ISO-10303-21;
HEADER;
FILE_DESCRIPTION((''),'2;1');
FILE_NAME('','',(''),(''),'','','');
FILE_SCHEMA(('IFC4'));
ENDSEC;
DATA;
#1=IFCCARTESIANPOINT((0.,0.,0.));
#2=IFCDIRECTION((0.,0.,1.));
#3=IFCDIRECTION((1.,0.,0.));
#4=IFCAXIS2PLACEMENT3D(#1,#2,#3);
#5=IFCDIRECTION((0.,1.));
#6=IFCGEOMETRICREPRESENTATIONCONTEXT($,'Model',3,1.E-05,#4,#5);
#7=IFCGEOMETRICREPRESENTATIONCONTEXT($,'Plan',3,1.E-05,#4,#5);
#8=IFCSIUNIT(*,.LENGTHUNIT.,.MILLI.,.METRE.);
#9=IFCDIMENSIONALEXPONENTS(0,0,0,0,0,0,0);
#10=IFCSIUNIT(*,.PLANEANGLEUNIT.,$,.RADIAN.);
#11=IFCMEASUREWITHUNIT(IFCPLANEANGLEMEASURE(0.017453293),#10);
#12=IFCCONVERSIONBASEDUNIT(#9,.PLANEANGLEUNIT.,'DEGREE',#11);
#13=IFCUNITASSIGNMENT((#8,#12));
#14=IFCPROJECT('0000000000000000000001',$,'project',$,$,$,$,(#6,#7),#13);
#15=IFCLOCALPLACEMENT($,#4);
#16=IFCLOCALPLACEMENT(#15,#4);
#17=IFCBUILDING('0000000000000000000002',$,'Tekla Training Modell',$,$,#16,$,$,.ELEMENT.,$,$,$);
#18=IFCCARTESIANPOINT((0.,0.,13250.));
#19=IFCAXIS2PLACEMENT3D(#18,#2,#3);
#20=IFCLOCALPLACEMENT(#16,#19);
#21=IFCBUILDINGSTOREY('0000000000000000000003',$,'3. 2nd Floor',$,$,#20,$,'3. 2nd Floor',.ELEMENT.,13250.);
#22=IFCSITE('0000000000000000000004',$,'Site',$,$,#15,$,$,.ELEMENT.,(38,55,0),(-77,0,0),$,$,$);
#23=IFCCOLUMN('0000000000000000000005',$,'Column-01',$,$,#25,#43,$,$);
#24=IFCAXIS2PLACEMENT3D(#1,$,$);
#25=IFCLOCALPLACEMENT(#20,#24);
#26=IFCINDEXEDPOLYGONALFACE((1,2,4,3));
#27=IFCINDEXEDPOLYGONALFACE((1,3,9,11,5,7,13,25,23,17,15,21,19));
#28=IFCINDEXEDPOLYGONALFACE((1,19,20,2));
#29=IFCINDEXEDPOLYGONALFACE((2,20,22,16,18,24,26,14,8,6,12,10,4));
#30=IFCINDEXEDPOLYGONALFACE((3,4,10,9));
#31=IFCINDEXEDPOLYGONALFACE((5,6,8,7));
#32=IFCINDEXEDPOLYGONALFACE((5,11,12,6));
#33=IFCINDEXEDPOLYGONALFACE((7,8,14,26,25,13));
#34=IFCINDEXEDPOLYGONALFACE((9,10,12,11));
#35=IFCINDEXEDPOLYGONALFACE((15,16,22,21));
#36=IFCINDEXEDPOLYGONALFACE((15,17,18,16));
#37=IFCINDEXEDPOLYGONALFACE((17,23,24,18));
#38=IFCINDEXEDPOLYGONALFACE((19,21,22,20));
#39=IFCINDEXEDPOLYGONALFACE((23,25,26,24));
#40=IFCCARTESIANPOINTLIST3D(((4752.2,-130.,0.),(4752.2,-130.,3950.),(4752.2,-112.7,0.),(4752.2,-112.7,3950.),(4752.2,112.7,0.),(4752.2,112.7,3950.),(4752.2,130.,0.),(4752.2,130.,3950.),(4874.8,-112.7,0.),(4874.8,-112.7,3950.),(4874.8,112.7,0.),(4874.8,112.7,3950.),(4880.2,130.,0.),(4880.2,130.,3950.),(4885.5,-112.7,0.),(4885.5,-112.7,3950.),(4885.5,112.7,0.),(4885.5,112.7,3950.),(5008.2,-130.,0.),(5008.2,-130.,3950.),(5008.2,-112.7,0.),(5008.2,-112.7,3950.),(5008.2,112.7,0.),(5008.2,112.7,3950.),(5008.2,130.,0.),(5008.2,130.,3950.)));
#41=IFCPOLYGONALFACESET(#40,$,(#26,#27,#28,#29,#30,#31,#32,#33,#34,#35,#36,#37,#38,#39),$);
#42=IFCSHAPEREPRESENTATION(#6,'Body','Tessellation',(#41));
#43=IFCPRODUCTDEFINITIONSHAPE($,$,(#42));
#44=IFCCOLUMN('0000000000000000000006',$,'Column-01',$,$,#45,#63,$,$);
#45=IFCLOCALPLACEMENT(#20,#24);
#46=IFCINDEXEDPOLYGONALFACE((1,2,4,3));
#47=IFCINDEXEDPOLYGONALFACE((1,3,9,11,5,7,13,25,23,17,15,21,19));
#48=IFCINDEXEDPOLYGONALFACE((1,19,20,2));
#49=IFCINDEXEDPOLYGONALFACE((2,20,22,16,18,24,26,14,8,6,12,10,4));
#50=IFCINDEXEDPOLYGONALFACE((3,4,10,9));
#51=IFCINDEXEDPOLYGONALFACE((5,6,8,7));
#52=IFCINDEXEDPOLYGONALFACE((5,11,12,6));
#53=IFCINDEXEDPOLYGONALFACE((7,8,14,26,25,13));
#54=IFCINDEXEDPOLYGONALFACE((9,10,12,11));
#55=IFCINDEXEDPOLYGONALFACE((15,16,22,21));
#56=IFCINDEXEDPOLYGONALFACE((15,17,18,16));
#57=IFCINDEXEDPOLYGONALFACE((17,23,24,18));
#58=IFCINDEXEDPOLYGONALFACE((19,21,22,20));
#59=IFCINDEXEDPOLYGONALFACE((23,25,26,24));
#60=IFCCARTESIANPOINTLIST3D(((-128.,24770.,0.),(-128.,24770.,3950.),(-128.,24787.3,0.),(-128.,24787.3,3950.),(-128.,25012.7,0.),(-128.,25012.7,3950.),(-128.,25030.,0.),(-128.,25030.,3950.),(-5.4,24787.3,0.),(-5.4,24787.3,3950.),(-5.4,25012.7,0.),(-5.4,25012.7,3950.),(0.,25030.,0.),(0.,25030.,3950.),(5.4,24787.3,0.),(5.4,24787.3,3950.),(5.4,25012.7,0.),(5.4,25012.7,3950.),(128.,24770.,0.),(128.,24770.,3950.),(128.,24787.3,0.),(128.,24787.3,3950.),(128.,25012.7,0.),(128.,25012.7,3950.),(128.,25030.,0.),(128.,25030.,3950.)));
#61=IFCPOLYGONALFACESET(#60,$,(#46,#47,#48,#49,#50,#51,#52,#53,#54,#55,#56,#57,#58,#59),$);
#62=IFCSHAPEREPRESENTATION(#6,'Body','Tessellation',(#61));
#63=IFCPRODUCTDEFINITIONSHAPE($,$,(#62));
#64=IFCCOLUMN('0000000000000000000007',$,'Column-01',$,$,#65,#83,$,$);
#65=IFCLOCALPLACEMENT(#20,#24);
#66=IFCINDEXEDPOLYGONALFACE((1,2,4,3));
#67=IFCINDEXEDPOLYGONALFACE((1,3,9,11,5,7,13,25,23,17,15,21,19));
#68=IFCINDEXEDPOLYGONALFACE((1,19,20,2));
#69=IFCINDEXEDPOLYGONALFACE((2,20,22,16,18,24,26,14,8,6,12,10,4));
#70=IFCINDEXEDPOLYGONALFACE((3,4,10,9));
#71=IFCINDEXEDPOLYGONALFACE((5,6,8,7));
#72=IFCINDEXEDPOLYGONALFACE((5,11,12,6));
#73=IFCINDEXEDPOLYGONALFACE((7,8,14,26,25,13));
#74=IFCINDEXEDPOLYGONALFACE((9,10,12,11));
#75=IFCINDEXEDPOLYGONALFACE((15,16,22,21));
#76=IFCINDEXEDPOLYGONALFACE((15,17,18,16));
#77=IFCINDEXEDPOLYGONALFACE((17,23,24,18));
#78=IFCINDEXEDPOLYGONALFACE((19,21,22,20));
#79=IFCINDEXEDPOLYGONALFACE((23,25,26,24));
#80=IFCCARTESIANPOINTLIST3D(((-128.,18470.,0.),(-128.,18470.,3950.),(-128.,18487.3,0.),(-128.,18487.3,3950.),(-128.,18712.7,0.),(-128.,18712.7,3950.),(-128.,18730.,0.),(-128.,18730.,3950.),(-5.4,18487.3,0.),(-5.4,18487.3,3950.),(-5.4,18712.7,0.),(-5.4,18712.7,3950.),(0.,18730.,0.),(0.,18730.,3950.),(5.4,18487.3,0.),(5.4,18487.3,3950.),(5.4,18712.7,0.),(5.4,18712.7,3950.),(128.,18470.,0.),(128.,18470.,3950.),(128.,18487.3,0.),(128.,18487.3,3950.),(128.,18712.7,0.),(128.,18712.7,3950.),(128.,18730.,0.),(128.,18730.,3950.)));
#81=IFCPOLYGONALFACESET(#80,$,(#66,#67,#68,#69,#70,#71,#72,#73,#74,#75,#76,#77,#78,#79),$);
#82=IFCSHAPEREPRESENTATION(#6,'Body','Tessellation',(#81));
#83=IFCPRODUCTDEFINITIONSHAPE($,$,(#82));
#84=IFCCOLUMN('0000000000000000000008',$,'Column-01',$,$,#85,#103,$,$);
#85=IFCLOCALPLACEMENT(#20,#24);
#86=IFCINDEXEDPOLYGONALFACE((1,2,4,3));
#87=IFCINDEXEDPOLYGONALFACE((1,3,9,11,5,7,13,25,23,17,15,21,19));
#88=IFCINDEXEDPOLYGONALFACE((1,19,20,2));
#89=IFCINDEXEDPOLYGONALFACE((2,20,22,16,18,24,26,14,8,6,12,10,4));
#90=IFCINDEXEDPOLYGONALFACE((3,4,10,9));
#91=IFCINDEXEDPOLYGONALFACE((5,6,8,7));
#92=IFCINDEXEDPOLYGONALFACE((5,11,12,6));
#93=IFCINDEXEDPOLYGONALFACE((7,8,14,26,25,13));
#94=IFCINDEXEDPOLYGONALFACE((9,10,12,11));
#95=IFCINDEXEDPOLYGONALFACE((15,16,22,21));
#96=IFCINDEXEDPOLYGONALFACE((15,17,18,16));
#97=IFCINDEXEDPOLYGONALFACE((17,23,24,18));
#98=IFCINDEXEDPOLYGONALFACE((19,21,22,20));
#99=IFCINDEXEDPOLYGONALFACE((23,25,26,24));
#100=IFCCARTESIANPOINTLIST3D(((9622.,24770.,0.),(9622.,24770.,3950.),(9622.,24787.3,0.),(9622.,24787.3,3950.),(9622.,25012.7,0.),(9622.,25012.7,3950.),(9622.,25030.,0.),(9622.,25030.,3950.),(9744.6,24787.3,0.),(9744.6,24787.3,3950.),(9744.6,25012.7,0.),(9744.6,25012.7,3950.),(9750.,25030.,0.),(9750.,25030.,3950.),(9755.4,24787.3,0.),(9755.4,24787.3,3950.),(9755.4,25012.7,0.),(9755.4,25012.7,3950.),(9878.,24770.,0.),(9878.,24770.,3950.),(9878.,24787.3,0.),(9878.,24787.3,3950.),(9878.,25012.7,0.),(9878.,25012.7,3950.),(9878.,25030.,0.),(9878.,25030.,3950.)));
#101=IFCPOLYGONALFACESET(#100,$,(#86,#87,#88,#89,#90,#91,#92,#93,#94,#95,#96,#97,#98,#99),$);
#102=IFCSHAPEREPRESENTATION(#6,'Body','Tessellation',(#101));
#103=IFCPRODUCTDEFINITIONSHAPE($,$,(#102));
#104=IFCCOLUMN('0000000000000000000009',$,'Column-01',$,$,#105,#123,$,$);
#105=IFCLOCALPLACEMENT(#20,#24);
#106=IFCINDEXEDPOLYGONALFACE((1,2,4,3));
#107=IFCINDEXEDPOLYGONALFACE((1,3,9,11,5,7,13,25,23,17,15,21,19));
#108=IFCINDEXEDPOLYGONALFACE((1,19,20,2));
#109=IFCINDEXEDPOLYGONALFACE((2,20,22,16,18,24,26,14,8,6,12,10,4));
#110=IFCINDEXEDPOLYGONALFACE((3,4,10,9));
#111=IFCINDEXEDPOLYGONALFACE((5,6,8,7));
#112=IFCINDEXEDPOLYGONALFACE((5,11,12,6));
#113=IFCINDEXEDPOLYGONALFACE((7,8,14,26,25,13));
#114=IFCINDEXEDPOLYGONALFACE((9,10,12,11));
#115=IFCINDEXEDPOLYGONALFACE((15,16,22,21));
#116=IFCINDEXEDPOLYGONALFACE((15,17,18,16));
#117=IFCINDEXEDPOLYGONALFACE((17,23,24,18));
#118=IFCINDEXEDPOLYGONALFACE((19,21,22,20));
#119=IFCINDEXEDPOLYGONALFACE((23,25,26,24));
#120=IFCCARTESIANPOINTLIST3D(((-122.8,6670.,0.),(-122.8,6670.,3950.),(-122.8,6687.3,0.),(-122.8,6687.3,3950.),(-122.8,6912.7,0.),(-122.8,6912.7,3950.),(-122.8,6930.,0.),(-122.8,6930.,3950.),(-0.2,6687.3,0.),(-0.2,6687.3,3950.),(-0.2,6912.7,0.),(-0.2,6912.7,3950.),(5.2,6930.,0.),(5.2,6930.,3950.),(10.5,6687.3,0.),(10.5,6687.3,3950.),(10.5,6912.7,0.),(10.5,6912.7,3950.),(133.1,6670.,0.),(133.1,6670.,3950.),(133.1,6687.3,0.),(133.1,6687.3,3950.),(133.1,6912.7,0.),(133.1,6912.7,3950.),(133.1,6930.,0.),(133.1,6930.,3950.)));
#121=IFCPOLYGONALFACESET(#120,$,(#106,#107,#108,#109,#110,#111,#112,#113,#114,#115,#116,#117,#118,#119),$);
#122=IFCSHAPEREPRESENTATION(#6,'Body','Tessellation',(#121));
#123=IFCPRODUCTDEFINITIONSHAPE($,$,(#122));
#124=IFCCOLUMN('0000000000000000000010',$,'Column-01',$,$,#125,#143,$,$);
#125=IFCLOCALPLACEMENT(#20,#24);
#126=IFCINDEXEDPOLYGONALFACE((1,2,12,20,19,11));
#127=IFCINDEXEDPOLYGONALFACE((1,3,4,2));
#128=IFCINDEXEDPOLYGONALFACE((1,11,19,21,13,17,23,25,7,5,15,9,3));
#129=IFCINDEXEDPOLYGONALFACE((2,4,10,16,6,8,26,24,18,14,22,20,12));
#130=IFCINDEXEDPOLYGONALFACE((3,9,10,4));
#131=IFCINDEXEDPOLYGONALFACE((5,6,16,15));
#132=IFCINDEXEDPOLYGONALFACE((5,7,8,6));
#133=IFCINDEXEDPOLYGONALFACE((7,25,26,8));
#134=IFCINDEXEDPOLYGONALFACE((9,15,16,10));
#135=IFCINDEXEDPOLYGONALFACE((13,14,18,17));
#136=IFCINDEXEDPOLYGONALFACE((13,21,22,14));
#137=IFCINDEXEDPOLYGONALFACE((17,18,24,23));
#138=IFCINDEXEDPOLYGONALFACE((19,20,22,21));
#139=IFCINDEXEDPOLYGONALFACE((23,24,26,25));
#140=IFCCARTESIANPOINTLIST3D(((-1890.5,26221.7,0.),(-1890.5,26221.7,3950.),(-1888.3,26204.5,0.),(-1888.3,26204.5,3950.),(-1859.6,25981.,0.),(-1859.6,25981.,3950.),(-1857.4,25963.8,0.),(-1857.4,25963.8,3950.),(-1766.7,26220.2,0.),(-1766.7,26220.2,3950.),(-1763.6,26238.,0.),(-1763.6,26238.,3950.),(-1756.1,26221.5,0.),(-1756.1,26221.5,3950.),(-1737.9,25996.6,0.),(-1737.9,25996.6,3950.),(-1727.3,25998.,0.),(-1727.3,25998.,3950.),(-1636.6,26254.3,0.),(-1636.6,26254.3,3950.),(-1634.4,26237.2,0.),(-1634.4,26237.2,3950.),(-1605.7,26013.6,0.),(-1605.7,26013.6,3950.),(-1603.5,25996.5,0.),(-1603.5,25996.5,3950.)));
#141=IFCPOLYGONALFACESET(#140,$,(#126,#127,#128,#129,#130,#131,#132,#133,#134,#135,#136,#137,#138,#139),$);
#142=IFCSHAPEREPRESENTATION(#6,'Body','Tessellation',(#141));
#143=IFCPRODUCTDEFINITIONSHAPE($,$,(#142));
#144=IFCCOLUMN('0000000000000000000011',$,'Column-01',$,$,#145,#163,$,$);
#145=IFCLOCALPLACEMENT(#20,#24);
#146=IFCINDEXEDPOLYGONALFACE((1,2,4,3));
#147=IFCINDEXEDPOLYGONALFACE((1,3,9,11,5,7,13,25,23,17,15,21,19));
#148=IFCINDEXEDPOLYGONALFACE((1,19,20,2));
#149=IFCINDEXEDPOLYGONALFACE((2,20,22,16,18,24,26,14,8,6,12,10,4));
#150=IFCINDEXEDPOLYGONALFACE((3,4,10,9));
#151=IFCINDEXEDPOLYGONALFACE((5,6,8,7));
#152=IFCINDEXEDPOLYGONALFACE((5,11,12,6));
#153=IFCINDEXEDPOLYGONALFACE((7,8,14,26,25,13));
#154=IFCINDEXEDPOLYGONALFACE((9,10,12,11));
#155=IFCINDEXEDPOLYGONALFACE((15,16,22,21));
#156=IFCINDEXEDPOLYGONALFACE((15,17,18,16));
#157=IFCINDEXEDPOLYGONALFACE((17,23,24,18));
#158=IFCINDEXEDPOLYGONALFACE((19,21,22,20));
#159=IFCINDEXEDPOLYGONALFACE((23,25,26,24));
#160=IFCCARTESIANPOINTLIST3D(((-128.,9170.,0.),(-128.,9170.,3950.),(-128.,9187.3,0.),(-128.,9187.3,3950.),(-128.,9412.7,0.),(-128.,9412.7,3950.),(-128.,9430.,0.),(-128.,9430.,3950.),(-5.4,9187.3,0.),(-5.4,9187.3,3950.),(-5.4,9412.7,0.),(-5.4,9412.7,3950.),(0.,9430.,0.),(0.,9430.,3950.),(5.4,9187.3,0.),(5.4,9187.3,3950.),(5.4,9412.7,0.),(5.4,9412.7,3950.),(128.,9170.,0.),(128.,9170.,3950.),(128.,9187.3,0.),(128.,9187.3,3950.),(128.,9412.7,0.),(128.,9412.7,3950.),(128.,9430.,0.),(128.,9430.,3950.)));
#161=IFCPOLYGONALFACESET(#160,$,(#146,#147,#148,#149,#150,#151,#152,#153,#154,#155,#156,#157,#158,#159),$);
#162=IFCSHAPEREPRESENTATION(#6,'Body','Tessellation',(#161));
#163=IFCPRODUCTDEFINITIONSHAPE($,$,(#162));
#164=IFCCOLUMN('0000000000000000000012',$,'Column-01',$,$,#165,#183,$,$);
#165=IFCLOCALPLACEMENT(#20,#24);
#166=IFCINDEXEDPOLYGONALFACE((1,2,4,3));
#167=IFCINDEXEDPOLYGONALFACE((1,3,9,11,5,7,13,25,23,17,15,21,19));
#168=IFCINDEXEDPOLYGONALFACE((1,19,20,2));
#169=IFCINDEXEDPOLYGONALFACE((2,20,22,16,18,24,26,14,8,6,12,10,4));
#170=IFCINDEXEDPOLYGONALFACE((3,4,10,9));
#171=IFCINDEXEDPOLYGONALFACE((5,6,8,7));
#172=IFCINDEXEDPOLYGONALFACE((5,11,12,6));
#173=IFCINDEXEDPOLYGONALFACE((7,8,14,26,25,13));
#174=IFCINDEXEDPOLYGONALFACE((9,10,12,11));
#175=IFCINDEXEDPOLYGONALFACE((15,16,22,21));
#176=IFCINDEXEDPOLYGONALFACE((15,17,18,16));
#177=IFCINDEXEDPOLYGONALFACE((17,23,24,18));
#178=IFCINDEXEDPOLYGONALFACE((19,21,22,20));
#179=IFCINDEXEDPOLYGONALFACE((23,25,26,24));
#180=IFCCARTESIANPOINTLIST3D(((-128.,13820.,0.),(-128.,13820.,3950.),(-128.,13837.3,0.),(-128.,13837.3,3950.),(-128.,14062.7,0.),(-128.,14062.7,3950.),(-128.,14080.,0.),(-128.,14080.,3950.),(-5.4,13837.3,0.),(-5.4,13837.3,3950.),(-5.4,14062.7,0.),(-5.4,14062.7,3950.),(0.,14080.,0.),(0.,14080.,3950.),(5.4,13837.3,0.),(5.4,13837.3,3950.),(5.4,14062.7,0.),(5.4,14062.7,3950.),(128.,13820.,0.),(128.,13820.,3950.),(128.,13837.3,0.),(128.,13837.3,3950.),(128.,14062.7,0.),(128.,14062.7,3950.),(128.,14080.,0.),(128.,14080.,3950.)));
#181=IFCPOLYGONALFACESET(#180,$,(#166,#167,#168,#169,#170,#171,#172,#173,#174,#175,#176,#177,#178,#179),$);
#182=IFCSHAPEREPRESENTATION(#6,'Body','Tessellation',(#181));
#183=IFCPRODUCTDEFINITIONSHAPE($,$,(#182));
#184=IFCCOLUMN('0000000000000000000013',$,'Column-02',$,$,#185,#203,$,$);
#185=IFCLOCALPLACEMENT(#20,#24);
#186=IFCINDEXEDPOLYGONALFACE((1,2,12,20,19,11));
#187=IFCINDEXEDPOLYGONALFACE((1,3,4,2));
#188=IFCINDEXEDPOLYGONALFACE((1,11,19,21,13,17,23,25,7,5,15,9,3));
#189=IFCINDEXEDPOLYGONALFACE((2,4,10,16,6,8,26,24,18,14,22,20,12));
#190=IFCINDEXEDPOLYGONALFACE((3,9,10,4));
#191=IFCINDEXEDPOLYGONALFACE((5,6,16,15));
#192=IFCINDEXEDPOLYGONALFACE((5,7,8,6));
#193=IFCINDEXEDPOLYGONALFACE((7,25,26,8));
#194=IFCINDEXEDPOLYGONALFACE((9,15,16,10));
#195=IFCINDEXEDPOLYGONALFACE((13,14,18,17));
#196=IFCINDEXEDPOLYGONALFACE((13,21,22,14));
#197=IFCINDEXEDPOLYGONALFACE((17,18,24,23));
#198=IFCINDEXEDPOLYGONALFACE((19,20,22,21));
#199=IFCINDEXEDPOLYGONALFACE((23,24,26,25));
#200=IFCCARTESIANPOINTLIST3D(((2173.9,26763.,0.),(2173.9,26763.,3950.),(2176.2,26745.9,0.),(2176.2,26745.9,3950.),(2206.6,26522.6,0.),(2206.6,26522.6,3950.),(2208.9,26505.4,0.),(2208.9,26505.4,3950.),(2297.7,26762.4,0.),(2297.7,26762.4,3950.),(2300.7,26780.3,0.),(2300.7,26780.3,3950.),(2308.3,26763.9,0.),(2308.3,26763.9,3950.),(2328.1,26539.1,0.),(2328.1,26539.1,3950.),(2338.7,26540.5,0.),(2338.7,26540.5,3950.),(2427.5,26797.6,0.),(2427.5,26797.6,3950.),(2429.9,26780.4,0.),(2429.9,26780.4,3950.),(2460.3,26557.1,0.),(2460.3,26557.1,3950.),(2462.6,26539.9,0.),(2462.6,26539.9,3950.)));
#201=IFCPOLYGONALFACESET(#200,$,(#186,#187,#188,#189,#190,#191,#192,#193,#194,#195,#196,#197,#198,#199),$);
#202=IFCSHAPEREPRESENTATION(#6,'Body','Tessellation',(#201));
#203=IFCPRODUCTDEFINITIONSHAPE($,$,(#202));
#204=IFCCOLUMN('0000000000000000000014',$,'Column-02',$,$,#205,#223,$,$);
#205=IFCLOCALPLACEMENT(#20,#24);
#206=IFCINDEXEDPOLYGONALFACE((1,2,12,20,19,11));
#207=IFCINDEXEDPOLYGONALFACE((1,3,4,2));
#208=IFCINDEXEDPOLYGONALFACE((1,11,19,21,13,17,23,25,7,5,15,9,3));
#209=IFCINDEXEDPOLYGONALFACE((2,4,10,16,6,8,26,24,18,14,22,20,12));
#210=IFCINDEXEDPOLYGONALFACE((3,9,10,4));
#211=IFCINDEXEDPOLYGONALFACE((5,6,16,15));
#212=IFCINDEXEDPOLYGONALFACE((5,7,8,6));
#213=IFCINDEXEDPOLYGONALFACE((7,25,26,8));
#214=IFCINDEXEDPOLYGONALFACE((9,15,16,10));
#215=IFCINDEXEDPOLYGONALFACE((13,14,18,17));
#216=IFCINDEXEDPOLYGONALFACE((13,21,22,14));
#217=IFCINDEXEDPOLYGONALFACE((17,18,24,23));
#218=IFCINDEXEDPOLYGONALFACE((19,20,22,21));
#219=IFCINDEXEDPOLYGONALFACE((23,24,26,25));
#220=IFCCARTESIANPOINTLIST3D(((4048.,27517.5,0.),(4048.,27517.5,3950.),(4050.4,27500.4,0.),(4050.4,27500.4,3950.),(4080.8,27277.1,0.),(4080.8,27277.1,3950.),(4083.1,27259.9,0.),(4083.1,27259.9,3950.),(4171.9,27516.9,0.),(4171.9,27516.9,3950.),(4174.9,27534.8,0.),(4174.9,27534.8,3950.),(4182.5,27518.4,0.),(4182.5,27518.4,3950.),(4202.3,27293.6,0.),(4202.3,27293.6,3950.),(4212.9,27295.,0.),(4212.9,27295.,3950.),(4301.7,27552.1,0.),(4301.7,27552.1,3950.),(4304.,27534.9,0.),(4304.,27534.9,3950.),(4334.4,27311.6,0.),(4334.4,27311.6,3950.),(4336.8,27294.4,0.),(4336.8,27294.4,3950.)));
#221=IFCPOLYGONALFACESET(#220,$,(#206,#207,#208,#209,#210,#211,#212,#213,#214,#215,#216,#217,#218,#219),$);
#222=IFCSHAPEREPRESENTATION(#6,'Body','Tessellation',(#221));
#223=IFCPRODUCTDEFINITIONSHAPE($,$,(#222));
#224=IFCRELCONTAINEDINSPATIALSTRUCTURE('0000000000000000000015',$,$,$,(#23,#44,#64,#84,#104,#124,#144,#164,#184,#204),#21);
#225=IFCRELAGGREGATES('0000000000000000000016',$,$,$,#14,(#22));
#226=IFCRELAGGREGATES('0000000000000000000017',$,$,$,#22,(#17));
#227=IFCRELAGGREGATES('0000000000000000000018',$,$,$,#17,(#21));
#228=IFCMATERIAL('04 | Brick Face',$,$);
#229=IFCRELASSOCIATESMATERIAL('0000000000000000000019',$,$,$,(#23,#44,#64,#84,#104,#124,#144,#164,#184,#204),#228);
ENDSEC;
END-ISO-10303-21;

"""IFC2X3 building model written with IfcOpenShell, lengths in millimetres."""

from ifc_helpers import new_model, entity, si_unit, converted_unit, direction, frame, origin_with_axes, place, context, project, spatial, polyline, outline, extrude, material, element, save


model = new_model("IFC2X3")

# Units and contexts
model_context = context("Model", 3, precision=1e-05, world=origin_with_axes(), true_north=direction((0.0, 1.0)))
plan_context = context("Plan", 3, precision=1e-05, world=origin_with_axes(), true_north=direction((0.0, 1.0)))
ifc_project = project(units=[si_unit("LENGTHUNIT", "METRE", prefix="MILLI"), converted_unit("PLANEANGLEUNIT", "DEGREE", entity("IfcPlaneAngleMeasure", 0.017453293), si_unit("PLANEANGLEUNIT", "RADIAN"), dimensions=[0, 0, 0, 0, 0, 0, 0])], contexts=[model_context, plan_context])

# Site, building, storey
site_placement = place(None, origin_with_axes())
site = spatial("IfcSite", under=ifc_project, at=site_placement, Name="Site", CompositionType="ELEMENT", RefLatitude=(38, 55, 0), RefLongitude=(-77, 0, 0))
building_placement = place(site_placement, origin_with_axes())
building = spatial("IfcBuilding", under=site, at=building_placement, Name="Tekla Training Modell", CompositionType="ELEMENT")
storey_placement = place(building_placement, frame((0.0, 0.0, 13250.0), z_axis=(0.0, 0.0, 1.0), x_axis=(1.0, 0.0, 0.0)))
storey = spatial("IfcBuildingStorey", under=building, at=storey_placement, Name="3. 2nd Floor", LongName="3. 2nd Floor", CompositionType="ELEMENT", Elevation=13250.0)

# Columns
ifc_material_1 = material(Name="04 | Brick Face")
for number, where, z_axis, x_axis, name in (
    (1, (4880.1, 0.0, 0.0), (0.0, 0.0, 1.0), (1.0, 0.0, 0.0), "Column-01"),
    (2, (0.0, 24900.0, 0.0), (0.0, 0.0, 1.0), (1.0, 0.0, 0.0), "Column-01"),
    (3, (0.0, 18600.0, 0.0), (0.0, 0.0, 1.0), (1.0, 0.0, 0.0), "Column-01"),
    (4, (9750.0, 24900.0, 0.0), (0.0, 0.0, 1.0), (1.0, 0.0, 0.0), "Column-01"),
    (5, (5.2, 6800.0, 0.0), (0.0, 0.0, 1.0), (1.0, 0.0, 0.0), "Column-01"),
    (6, (-1747.0, 26109.1, 0.0), (0.0, 0.0, 1.0), (0.991827, 0.127587, 0.0), "Column-01"),
    (7, (0.0, 9300.0, 0.0), (0.0, 0.0, 1.0), (1.0, 0.0, 0.0), "Column-01"),
    (8, (0.0, 13950.0, 0.0), (0.0, 0.0, 1.0), (1.0, 0.0, 0.0), "Column-01"),
    (9, (2318.2, 26651.5, 0.0), (0.0, 0.0, 1.0), (0.990872, 0.134803, 0.0), "Column-02"),
    (10, (4192.4, 27406.0, 0.0), (0.0, 0.0, 1.0), (0.990872, 0.134803, 0.0), "Column-02"),
):
    element("IfcColumn", number, at=place(storey_placement, frame(where, z_axis=z_axis, x_axis=x_axis)), inside=storey, material=ifc_material_1, Name=name, context=model_context, shape_type="SweptSolid", body=[
        extrude(outline(polyline([(0.0, 130.0), (-128.0, 130.0), (-128.0, 112.7), (-5.3, 112.7), (-5.3, -112.7), (-128.0, -112.7), (-128.0, -130.0), (128.0, -130.0), (128.0, -112.7), (5.3, -112.7), (5.3, 112.7), (128.0, 112.7), (128.0, 130.0), (0.0, 130.0)])), origin_with_axes(), (0.0, 0.0, 1.0), 3950.0),
    ])

save(model, "model.ifc")
